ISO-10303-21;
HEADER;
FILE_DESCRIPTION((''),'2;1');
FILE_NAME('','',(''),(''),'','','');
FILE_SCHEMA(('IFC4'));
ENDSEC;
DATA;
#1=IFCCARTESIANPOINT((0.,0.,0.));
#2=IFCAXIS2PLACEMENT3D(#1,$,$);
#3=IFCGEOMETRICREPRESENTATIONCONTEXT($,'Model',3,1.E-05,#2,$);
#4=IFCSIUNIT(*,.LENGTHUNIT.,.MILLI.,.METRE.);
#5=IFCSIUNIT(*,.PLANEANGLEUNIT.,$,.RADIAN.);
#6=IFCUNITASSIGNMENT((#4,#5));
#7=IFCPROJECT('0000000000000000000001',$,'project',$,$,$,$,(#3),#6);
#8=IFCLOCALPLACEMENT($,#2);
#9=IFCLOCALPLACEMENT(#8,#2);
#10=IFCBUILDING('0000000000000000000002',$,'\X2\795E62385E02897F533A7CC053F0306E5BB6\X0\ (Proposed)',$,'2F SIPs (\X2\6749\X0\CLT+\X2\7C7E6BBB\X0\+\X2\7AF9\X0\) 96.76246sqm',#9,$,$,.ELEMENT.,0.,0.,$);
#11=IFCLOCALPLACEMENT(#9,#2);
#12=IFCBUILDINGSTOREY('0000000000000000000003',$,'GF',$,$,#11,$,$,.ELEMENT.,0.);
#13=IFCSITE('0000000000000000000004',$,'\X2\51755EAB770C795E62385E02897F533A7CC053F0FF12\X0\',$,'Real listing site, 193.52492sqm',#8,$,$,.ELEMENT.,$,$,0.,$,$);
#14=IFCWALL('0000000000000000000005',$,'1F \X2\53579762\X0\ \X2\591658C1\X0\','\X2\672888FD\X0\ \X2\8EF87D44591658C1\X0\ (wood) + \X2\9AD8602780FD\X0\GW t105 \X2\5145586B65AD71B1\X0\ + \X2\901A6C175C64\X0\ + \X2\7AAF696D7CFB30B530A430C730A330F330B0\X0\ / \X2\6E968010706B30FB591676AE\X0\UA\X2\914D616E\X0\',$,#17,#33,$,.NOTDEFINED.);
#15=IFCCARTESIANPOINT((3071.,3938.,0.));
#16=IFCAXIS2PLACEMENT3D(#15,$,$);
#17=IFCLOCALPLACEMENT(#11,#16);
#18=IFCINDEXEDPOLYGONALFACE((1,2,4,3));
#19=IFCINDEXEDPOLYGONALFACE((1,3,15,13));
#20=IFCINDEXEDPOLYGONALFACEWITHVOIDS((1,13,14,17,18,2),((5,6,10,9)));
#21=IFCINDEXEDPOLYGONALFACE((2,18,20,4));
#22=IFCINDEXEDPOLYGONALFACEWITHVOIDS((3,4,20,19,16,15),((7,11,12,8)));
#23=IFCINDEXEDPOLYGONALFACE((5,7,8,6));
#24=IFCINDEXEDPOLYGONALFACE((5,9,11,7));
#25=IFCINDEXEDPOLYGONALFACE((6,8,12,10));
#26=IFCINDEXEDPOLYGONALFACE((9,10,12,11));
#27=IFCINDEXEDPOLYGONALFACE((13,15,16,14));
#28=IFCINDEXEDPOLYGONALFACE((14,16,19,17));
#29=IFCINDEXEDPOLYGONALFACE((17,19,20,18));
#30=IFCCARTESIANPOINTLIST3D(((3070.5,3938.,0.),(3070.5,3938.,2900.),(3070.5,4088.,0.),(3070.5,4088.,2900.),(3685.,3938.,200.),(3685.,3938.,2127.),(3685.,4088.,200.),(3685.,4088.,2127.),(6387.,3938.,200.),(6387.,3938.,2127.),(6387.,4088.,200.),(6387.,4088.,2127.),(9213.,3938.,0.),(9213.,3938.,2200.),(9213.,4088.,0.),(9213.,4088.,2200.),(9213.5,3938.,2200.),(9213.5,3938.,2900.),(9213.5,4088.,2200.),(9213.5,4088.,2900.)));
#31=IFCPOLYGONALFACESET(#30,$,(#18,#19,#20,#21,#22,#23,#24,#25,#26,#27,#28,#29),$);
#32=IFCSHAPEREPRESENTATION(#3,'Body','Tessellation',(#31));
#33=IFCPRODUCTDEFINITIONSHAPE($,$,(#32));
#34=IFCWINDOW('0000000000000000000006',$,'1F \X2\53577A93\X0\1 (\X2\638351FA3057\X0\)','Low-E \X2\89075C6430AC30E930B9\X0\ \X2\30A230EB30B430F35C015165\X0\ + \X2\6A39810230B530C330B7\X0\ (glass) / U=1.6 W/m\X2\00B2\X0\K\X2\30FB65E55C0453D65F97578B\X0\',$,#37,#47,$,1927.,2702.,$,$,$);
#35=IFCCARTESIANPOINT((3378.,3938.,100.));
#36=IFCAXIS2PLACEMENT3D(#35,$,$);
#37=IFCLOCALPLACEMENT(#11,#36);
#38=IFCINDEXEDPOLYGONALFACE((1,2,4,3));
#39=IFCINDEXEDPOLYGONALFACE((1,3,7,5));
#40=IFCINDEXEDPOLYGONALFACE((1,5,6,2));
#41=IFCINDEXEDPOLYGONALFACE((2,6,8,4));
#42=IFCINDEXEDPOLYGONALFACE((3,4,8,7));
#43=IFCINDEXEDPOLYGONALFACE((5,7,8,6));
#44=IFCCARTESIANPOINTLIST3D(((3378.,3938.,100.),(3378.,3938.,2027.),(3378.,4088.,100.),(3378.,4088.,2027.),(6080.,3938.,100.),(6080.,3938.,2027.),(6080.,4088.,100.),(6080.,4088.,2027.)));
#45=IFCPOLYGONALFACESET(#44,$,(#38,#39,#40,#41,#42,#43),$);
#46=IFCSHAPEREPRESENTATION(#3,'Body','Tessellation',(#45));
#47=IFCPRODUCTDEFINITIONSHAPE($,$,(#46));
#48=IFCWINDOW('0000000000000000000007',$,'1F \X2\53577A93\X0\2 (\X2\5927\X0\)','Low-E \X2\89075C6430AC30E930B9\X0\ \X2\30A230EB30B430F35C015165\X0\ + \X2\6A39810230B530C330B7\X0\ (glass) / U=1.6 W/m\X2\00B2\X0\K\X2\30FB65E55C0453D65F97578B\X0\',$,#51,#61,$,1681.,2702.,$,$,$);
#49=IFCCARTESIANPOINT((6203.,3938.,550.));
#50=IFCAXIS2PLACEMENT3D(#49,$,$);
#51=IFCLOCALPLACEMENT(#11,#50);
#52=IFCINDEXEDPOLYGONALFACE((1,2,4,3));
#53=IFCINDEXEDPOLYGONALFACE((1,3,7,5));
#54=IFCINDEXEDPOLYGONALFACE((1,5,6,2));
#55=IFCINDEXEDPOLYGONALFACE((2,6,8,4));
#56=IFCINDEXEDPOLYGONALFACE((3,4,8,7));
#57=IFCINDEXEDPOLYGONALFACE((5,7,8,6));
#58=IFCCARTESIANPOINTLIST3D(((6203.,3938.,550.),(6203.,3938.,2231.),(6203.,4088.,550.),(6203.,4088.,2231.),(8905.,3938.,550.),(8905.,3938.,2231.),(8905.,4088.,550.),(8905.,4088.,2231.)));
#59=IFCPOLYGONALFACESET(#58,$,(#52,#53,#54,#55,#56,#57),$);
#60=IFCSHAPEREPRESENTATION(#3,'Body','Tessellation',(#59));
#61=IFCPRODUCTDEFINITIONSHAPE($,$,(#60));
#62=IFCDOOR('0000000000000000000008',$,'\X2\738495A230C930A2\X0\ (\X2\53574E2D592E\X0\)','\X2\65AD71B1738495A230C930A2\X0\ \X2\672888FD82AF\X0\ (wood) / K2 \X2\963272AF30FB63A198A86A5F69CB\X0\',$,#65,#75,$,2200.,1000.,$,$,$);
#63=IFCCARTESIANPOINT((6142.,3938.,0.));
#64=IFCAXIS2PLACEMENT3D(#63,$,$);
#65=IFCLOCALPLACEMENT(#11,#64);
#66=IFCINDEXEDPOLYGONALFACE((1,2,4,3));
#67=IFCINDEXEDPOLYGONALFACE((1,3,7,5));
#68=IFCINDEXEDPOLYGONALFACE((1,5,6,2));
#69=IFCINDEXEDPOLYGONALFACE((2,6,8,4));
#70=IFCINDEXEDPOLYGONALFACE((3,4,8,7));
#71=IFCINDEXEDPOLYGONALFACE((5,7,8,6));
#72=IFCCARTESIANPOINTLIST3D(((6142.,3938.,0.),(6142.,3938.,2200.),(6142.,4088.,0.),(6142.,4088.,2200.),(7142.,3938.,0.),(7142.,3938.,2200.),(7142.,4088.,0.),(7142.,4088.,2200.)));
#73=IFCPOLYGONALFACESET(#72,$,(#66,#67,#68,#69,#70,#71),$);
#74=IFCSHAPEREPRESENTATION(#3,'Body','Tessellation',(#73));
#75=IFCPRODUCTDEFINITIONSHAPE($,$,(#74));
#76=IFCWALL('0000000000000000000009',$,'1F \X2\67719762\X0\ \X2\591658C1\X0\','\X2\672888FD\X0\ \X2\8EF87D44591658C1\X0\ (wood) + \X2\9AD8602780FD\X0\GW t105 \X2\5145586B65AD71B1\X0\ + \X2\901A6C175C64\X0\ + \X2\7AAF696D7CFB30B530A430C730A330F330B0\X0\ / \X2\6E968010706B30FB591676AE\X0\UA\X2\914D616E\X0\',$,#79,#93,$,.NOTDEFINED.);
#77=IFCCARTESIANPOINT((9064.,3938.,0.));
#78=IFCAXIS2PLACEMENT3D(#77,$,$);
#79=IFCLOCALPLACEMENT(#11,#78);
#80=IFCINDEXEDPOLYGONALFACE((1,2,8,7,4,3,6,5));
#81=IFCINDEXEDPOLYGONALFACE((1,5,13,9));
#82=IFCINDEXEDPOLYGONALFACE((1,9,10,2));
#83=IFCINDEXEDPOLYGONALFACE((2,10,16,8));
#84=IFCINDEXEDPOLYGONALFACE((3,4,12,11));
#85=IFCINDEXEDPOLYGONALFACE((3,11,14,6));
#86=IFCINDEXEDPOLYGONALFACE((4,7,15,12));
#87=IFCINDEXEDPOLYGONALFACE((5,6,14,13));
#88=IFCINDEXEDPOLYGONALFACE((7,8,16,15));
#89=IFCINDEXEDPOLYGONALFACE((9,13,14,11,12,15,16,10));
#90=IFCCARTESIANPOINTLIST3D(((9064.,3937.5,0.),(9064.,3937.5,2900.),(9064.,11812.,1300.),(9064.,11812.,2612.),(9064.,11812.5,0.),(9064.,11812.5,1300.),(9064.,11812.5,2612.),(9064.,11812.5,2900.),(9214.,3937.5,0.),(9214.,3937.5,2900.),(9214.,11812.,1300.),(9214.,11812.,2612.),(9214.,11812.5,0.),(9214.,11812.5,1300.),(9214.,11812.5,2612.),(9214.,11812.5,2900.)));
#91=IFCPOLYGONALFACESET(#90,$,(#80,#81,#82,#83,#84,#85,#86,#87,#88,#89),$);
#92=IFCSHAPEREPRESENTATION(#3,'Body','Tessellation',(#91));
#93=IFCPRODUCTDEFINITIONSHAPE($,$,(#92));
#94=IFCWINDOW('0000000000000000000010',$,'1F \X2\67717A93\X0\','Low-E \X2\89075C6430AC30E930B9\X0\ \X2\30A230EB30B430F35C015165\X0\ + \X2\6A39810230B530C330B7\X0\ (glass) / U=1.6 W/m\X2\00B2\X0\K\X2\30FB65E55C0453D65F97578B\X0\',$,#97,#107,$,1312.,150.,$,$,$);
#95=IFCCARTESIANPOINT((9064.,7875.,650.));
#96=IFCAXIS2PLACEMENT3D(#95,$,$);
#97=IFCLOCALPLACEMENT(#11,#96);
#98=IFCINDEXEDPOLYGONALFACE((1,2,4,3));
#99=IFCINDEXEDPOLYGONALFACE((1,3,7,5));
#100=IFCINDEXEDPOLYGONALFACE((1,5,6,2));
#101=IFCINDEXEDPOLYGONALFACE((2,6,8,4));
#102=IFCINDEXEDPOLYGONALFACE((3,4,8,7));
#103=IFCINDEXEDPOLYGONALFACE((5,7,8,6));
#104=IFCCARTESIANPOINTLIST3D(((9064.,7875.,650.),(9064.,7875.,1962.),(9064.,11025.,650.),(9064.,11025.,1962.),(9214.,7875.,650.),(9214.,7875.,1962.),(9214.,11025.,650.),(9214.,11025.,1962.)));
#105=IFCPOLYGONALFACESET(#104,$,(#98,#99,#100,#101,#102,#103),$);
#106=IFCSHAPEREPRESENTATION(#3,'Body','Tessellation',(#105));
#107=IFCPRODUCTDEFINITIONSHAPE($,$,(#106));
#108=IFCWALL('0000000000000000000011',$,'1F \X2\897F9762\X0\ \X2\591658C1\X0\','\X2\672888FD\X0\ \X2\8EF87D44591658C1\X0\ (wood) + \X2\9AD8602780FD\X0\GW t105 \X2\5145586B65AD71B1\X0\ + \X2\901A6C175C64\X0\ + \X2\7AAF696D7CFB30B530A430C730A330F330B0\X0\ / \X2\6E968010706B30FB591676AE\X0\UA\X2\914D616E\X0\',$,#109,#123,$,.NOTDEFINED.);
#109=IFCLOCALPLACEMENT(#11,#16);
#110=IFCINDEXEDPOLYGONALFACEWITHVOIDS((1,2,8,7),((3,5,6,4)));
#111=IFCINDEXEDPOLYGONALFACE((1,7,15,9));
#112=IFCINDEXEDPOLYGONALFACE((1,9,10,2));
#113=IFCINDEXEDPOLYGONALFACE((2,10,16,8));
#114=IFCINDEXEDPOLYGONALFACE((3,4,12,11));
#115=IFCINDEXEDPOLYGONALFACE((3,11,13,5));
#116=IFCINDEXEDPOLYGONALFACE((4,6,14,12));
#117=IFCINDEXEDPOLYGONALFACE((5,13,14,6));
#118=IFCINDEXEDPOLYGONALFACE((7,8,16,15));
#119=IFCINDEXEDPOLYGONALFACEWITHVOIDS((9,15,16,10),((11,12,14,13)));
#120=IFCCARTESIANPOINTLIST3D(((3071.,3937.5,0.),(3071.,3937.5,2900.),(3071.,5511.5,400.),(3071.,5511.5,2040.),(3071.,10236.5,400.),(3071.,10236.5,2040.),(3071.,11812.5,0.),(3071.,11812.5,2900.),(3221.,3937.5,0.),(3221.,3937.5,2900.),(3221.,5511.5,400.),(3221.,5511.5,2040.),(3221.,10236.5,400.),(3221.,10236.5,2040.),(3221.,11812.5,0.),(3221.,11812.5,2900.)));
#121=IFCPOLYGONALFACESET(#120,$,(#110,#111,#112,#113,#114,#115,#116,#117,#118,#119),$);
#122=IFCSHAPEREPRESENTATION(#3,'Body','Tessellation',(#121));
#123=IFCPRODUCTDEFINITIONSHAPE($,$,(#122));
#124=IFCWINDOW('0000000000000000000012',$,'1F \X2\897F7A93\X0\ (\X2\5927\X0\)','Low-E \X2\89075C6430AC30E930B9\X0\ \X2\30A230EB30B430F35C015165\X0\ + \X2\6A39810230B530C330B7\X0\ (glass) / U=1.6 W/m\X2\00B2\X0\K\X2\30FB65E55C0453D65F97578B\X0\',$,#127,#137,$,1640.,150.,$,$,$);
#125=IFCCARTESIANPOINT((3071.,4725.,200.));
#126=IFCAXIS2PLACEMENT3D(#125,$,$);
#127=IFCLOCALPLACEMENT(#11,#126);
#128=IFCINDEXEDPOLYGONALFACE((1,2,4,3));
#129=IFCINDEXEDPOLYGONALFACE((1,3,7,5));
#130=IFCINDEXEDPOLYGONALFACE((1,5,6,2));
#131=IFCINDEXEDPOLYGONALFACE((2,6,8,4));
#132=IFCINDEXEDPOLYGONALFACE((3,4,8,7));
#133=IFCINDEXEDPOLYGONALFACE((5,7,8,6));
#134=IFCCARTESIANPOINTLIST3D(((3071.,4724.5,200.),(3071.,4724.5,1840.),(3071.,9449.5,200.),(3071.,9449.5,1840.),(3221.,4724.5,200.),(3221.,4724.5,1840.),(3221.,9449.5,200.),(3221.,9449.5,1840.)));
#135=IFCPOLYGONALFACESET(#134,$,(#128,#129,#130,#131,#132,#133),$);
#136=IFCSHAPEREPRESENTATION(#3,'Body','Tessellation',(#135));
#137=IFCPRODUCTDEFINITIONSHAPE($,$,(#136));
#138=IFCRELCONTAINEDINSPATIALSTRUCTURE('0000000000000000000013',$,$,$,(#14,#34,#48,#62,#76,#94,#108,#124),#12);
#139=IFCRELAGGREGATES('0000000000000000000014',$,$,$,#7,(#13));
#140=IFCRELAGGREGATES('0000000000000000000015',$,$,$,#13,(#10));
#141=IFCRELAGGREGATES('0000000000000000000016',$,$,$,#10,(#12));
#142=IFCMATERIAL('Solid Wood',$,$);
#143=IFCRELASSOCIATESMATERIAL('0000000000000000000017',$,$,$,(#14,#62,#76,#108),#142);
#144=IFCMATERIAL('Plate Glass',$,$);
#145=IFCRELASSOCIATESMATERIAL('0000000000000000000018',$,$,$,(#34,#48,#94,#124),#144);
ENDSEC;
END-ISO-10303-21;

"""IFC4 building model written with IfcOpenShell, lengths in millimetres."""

from ifc_helpers import new_model, si_unit, frame, frame_2d, origin, place, context, project, spatial, rectangle, extrude, material, element, fill, save


model = new_model("IFC4")

# Units and contexts
model_context = context("Model", 3, precision=1e-05, world=origin())
ifc_project = project(units=[si_unit("LENGTHUNIT", "METRE", prefix="MILLI"), si_unit("PLANEANGLEUNIT", "RADIAN")], contexts=[model_context])

# Site, building, storey
site_placement = place(None, origin())
site = spatial("IfcSite", under=ifc_project, at=site_placement, Name="兵庫県神戸市西区糀台２", ObjectType="Real listing site, 193.52492sqm", CompositionType="ELEMENT", RefElevation=0.0)
building_placement = place(site_placement, origin())
building = spatial("IfcBuilding", under=site, at=building_placement, Name="神戸市西区糀台の家 (Proposed)", ObjectType="2F SIPs (杉CLT+籾殻+竹) 96.76246sqm", CompositionType="ELEMENT", ElevationOfRefHeight=0.0, ElevationOfTerrain=0.0)
storey_placement = place(building_placement, origin())
storey = spatial("IfcBuildingStorey", under=building, at=storey_placement, Name="GF", CompositionType="ELEMENT", Elevation=0.0)

# Shared definitions
ifc_material_1 = material(Name="Solid Wood")

# Wall, openings, windows, door
wall_1_placement = place(storey_placement, frame((3071.0, 3938.0, 0.0)))
wall_1 = element("IfcWall", 1, at=wall_1_placement, inside=storey, material=ifc_material_1, Name="1F 南面 外壁", Description="木製 軸組外壁 (wood) + 高性能GW t105 充填断熱 + 通気層 + 窯業系サイディング / 準耐火・外皮UA配慮", PredefinedType="NOTDEFINED", context=model_context, shape_type="SweptSolid", body=[
    extrude(rectangle(XDim=6143.0, YDim=150.0, at=frame_2d((3071.0, 75.0))), frame((3071.0, 3938.0, 0.0)), (0.0, 0.0, 1.0), 2900.0),
])
opening_1_placement = place(storey_placement, frame((3378.0, 3938.0, 100.0)))
opening_1 = element("IfcOpeningElement", 2, at=opening_1_placement, cuts=wall_1, PredefinedType="NOTDEFINED", context=model_context, shape_type="SweptSolid", body=[
    extrude(rectangle(XDim=2702.0, YDim=150.0, at=frame_2d((1351.0, 75.0))), frame((3378.0, 3938.0, 100.0)), (0.0, 0.0, 1.0), 1927.0),
])
opening_2_placement = place(storey_placement, frame((6203.0, 3938.0, 550.0)))
opening_2 = element("IfcOpeningElement", 3, at=opening_2_placement, cuts=wall_1, PredefinedType="NOTDEFINED", context=model_context, shape_type="SweptSolid", body=[
    extrude(rectangle(XDim=2702.0, YDim=150.0, at=frame_2d((1351.0, 75.0))), frame((6203.0, 3938.0, 550.0)), (0.0, 0.0, 1.0), 1681.0),
])
opening_3_placement = place(storey_placement, frame((6142.0, 3938.0, 0.0)))
opening_3 = element("IfcOpeningElement", 4, at=opening_3_placement, cuts=wall_1, PredefinedType="NOTDEFINED", context=model_context, shape_type="SweptSolid", body=[
    extrude(rectangle(XDim=1000.0, YDim=150.0, at=frame_2d((500.0, 75.0))), frame((6142.0, 3938.0, 0.0)), (0.0, 0.0, 1.0), 2200.0),
])
ifc_material_2 = material(Name="Plate Glass")
window_1_placement = place(storey_placement, frame((3378.0, 3938.0, 100.0)))
window_1 = element("IfcWindow", 5, at=window_1_placement, inside=storey, material=ifc_material_2, Name="1F 南窓1 (掃出し)", Description="Low-E 複層ガラス アルゴン封入 + 樹脂サッシ (glass) / U=1.6 W/m²K・日射取得型", OverallHeight=1927.0, OverallWidth=2702.0, context=model_context, shape_type="SweptSolid", body=[
    extrude(rectangle(XDim=2702.0, YDim=150.0, at=frame_2d((1351.0, 75.0))), frame((3378.0, 3938.0, 100.0)), (0.0, 0.0, 1.0), 1927.0),
])
fill(opening_1, window_1)
window_2_placement = place(storey_placement, frame((6203.0, 3938.0, 550.0)))
window_2 = element("IfcWindow", 6, at=window_2_placement, inside=storey, material=ifc_material_2, Name="1F 南窓2 (大)", Description="Low-E 複層ガラス アルゴン封入 + 樹脂サッシ (glass) / U=1.6 W/m²K・日射取得型", OverallHeight=1681.0, OverallWidth=2702.0, context=model_context, shape_type="SweptSolid", body=[
    extrude(rectangle(XDim=2702.0, YDim=150.0, at=frame_2d((1351.0, 75.0))), frame((6203.0, 3938.0, 550.0)), (0.0, 0.0, 1.0), 1681.0),
])
fill(opening_2, window_2)
door_placement = place(storey_placement, frame((6142.0, 3938.0, 0.0)))
door = element("IfcDoor", 7, at=door_placement, inside=storey, material=ifc_material_1, Name="玄関ドア (南中央)", Description="断熱玄関ドア 木製芯 (wood) / K2 防犯・採風機構", OverallHeight=2200.0, OverallWidth=1000.0, context=model_context, shape_type="SweptSolid", body=[
    extrude(rectangle(XDim=1000.0, YDim=150.0, at=frame_2d((500.0, 75.0))), frame((6142.0, 3938.0, 0.0)), (0.0, 0.0, 1.0), 2200.0),
])
fill(opening_3, door)

# Walls, openings, windows
wall_2_placement = place(storey_placement, frame((9064.0, 3938.0, 0.0)))
wall_2 = element("IfcWall", 8, at=wall_2_placement, inside=storey, material=ifc_material_1, Name="1F 東面 外壁", Description="木製 軸組外壁 (wood) + 高性能GW t105 充填断熱 + 通気層 + 窯業系サイディング / 準耐火・外皮UA配慮", PredefinedType="NOTDEFINED", context=model_context, shape_type="SweptSolid", body=[
    extrude(rectangle(XDim=150.0, YDim=7875.0, at=frame_2d((75.0, 3937.0))), frame((9064.0, 3938.0, 0.0)), (0.0, 0.0, 1.0), 2900.0),
])
opening_4_placement = place(storey_placement, frame((9064.0, 7875.0, 650.0)))
opening_4 = element("IfcOpeningElement", 9, at=opening_4_placement, cuts=wall_2, PredefinedType="NOTDEFINED", context=model_context, shape_type="SweptSolid", body=[
    extrude(rectangle(XDim=150.0, YDim=3150.0, at=frame_2d((75.0, 1575.0))), frame((9064.0, 7875.0, 650.0)), (0.0, 0.0, 1.0), 1312.0),
])
window_3_placement = place(storey_placement, frame((9064.0, 7875.0, 650.0)))
window_3 = element("IfcWindow", 10, at=window_3_placement, inside=storey, material=ifc_material_2, Name="1F 東窓", Description="Low-E 複層ガラス アルゴン封入 + 樹脂サッシ (glass) / U=1.6 W/m²K・日射取得型", OverallHeight=1312.0, OverallWidth=150.0, context=model_context, shape_type="SweptSolid", body=[
    extrude(rectangle(XDim=150.0, YDim=3150.0, at=frame_2d((75.0, 1575.0))), frame((9064.0, 7875.0, 650.0)), (0.0, 0.0, 1.0), 1312.0),
])
fill(opening_4, window_3)
wall_3_placement = place(storey_placement, frame((3071.0, 3938.0, 0.0)))
wall_3 = element("IfcWall", 11, at=wall_3_placement, inside=storey, material=ifc_material_1, Name="1F 西面 外壁", Description="木製 軸組外壁 (wood) + 高性能GW t105 充填断熱 + 通気層 + 窯業系サイディング / 準耐火・外皮UA配慮", PredefinedType="NOTDEFINED", context=model_context, shape_type="SweptSolid", body=[
    extrude(rectangle(XDim=150.0, YDim=7875.0, at=frame_2d((75.0, 3937.0))), frame((3071.0, 3938.0, 0.0)), (0.0, 0.0, 1.0), 2900.0),
])
opening_5_placement = place(storey_placement, frame((3071.0, 4725.0, 200.0)))
opening_5 = element("IfcOpeningElement", 12, at=opening_5_placement, cuts=wall_3, PredefinedType="NOTDEFINED", context=model_context, shape_type="SweptSolid", body=[
    extrude(rectangle(XDim=150.0, YDim=4725.0, at=frame_2d((75.0, 2362.0))), frame((3071.0, 4725.0, 200.0)), (0.0, 0.0, 1.0), 1640.0),
])
window_4_placement = place(storey_placement, frame((3071.0, 4725.0, 200.0)))
window_4 = element("IfcWindow", 13, at=window_4_placement, inside=storey, material=ifc_material_2, Name="1F 西窓 (大)", Description="Low-E 複層ガラス アルゴン封入 + 樹脂サッシ (glass) / U=1.6 W/m²K・日射取得型", OverallHeight=1640.0, OverallWidth=150.0, context=model_context, shape_type="SweptSolid", body=[
    extrude(rectangle(XDim=150.0, YDim=4725.0, at=frame_2d((75.0, 2362.0))), frame((3071.0, 4725.0, 200.0)), (0.0, 0.0, 1.0), 1640.0),
])
fill(opening_5, window_4)

save(model, "model.ifc")
